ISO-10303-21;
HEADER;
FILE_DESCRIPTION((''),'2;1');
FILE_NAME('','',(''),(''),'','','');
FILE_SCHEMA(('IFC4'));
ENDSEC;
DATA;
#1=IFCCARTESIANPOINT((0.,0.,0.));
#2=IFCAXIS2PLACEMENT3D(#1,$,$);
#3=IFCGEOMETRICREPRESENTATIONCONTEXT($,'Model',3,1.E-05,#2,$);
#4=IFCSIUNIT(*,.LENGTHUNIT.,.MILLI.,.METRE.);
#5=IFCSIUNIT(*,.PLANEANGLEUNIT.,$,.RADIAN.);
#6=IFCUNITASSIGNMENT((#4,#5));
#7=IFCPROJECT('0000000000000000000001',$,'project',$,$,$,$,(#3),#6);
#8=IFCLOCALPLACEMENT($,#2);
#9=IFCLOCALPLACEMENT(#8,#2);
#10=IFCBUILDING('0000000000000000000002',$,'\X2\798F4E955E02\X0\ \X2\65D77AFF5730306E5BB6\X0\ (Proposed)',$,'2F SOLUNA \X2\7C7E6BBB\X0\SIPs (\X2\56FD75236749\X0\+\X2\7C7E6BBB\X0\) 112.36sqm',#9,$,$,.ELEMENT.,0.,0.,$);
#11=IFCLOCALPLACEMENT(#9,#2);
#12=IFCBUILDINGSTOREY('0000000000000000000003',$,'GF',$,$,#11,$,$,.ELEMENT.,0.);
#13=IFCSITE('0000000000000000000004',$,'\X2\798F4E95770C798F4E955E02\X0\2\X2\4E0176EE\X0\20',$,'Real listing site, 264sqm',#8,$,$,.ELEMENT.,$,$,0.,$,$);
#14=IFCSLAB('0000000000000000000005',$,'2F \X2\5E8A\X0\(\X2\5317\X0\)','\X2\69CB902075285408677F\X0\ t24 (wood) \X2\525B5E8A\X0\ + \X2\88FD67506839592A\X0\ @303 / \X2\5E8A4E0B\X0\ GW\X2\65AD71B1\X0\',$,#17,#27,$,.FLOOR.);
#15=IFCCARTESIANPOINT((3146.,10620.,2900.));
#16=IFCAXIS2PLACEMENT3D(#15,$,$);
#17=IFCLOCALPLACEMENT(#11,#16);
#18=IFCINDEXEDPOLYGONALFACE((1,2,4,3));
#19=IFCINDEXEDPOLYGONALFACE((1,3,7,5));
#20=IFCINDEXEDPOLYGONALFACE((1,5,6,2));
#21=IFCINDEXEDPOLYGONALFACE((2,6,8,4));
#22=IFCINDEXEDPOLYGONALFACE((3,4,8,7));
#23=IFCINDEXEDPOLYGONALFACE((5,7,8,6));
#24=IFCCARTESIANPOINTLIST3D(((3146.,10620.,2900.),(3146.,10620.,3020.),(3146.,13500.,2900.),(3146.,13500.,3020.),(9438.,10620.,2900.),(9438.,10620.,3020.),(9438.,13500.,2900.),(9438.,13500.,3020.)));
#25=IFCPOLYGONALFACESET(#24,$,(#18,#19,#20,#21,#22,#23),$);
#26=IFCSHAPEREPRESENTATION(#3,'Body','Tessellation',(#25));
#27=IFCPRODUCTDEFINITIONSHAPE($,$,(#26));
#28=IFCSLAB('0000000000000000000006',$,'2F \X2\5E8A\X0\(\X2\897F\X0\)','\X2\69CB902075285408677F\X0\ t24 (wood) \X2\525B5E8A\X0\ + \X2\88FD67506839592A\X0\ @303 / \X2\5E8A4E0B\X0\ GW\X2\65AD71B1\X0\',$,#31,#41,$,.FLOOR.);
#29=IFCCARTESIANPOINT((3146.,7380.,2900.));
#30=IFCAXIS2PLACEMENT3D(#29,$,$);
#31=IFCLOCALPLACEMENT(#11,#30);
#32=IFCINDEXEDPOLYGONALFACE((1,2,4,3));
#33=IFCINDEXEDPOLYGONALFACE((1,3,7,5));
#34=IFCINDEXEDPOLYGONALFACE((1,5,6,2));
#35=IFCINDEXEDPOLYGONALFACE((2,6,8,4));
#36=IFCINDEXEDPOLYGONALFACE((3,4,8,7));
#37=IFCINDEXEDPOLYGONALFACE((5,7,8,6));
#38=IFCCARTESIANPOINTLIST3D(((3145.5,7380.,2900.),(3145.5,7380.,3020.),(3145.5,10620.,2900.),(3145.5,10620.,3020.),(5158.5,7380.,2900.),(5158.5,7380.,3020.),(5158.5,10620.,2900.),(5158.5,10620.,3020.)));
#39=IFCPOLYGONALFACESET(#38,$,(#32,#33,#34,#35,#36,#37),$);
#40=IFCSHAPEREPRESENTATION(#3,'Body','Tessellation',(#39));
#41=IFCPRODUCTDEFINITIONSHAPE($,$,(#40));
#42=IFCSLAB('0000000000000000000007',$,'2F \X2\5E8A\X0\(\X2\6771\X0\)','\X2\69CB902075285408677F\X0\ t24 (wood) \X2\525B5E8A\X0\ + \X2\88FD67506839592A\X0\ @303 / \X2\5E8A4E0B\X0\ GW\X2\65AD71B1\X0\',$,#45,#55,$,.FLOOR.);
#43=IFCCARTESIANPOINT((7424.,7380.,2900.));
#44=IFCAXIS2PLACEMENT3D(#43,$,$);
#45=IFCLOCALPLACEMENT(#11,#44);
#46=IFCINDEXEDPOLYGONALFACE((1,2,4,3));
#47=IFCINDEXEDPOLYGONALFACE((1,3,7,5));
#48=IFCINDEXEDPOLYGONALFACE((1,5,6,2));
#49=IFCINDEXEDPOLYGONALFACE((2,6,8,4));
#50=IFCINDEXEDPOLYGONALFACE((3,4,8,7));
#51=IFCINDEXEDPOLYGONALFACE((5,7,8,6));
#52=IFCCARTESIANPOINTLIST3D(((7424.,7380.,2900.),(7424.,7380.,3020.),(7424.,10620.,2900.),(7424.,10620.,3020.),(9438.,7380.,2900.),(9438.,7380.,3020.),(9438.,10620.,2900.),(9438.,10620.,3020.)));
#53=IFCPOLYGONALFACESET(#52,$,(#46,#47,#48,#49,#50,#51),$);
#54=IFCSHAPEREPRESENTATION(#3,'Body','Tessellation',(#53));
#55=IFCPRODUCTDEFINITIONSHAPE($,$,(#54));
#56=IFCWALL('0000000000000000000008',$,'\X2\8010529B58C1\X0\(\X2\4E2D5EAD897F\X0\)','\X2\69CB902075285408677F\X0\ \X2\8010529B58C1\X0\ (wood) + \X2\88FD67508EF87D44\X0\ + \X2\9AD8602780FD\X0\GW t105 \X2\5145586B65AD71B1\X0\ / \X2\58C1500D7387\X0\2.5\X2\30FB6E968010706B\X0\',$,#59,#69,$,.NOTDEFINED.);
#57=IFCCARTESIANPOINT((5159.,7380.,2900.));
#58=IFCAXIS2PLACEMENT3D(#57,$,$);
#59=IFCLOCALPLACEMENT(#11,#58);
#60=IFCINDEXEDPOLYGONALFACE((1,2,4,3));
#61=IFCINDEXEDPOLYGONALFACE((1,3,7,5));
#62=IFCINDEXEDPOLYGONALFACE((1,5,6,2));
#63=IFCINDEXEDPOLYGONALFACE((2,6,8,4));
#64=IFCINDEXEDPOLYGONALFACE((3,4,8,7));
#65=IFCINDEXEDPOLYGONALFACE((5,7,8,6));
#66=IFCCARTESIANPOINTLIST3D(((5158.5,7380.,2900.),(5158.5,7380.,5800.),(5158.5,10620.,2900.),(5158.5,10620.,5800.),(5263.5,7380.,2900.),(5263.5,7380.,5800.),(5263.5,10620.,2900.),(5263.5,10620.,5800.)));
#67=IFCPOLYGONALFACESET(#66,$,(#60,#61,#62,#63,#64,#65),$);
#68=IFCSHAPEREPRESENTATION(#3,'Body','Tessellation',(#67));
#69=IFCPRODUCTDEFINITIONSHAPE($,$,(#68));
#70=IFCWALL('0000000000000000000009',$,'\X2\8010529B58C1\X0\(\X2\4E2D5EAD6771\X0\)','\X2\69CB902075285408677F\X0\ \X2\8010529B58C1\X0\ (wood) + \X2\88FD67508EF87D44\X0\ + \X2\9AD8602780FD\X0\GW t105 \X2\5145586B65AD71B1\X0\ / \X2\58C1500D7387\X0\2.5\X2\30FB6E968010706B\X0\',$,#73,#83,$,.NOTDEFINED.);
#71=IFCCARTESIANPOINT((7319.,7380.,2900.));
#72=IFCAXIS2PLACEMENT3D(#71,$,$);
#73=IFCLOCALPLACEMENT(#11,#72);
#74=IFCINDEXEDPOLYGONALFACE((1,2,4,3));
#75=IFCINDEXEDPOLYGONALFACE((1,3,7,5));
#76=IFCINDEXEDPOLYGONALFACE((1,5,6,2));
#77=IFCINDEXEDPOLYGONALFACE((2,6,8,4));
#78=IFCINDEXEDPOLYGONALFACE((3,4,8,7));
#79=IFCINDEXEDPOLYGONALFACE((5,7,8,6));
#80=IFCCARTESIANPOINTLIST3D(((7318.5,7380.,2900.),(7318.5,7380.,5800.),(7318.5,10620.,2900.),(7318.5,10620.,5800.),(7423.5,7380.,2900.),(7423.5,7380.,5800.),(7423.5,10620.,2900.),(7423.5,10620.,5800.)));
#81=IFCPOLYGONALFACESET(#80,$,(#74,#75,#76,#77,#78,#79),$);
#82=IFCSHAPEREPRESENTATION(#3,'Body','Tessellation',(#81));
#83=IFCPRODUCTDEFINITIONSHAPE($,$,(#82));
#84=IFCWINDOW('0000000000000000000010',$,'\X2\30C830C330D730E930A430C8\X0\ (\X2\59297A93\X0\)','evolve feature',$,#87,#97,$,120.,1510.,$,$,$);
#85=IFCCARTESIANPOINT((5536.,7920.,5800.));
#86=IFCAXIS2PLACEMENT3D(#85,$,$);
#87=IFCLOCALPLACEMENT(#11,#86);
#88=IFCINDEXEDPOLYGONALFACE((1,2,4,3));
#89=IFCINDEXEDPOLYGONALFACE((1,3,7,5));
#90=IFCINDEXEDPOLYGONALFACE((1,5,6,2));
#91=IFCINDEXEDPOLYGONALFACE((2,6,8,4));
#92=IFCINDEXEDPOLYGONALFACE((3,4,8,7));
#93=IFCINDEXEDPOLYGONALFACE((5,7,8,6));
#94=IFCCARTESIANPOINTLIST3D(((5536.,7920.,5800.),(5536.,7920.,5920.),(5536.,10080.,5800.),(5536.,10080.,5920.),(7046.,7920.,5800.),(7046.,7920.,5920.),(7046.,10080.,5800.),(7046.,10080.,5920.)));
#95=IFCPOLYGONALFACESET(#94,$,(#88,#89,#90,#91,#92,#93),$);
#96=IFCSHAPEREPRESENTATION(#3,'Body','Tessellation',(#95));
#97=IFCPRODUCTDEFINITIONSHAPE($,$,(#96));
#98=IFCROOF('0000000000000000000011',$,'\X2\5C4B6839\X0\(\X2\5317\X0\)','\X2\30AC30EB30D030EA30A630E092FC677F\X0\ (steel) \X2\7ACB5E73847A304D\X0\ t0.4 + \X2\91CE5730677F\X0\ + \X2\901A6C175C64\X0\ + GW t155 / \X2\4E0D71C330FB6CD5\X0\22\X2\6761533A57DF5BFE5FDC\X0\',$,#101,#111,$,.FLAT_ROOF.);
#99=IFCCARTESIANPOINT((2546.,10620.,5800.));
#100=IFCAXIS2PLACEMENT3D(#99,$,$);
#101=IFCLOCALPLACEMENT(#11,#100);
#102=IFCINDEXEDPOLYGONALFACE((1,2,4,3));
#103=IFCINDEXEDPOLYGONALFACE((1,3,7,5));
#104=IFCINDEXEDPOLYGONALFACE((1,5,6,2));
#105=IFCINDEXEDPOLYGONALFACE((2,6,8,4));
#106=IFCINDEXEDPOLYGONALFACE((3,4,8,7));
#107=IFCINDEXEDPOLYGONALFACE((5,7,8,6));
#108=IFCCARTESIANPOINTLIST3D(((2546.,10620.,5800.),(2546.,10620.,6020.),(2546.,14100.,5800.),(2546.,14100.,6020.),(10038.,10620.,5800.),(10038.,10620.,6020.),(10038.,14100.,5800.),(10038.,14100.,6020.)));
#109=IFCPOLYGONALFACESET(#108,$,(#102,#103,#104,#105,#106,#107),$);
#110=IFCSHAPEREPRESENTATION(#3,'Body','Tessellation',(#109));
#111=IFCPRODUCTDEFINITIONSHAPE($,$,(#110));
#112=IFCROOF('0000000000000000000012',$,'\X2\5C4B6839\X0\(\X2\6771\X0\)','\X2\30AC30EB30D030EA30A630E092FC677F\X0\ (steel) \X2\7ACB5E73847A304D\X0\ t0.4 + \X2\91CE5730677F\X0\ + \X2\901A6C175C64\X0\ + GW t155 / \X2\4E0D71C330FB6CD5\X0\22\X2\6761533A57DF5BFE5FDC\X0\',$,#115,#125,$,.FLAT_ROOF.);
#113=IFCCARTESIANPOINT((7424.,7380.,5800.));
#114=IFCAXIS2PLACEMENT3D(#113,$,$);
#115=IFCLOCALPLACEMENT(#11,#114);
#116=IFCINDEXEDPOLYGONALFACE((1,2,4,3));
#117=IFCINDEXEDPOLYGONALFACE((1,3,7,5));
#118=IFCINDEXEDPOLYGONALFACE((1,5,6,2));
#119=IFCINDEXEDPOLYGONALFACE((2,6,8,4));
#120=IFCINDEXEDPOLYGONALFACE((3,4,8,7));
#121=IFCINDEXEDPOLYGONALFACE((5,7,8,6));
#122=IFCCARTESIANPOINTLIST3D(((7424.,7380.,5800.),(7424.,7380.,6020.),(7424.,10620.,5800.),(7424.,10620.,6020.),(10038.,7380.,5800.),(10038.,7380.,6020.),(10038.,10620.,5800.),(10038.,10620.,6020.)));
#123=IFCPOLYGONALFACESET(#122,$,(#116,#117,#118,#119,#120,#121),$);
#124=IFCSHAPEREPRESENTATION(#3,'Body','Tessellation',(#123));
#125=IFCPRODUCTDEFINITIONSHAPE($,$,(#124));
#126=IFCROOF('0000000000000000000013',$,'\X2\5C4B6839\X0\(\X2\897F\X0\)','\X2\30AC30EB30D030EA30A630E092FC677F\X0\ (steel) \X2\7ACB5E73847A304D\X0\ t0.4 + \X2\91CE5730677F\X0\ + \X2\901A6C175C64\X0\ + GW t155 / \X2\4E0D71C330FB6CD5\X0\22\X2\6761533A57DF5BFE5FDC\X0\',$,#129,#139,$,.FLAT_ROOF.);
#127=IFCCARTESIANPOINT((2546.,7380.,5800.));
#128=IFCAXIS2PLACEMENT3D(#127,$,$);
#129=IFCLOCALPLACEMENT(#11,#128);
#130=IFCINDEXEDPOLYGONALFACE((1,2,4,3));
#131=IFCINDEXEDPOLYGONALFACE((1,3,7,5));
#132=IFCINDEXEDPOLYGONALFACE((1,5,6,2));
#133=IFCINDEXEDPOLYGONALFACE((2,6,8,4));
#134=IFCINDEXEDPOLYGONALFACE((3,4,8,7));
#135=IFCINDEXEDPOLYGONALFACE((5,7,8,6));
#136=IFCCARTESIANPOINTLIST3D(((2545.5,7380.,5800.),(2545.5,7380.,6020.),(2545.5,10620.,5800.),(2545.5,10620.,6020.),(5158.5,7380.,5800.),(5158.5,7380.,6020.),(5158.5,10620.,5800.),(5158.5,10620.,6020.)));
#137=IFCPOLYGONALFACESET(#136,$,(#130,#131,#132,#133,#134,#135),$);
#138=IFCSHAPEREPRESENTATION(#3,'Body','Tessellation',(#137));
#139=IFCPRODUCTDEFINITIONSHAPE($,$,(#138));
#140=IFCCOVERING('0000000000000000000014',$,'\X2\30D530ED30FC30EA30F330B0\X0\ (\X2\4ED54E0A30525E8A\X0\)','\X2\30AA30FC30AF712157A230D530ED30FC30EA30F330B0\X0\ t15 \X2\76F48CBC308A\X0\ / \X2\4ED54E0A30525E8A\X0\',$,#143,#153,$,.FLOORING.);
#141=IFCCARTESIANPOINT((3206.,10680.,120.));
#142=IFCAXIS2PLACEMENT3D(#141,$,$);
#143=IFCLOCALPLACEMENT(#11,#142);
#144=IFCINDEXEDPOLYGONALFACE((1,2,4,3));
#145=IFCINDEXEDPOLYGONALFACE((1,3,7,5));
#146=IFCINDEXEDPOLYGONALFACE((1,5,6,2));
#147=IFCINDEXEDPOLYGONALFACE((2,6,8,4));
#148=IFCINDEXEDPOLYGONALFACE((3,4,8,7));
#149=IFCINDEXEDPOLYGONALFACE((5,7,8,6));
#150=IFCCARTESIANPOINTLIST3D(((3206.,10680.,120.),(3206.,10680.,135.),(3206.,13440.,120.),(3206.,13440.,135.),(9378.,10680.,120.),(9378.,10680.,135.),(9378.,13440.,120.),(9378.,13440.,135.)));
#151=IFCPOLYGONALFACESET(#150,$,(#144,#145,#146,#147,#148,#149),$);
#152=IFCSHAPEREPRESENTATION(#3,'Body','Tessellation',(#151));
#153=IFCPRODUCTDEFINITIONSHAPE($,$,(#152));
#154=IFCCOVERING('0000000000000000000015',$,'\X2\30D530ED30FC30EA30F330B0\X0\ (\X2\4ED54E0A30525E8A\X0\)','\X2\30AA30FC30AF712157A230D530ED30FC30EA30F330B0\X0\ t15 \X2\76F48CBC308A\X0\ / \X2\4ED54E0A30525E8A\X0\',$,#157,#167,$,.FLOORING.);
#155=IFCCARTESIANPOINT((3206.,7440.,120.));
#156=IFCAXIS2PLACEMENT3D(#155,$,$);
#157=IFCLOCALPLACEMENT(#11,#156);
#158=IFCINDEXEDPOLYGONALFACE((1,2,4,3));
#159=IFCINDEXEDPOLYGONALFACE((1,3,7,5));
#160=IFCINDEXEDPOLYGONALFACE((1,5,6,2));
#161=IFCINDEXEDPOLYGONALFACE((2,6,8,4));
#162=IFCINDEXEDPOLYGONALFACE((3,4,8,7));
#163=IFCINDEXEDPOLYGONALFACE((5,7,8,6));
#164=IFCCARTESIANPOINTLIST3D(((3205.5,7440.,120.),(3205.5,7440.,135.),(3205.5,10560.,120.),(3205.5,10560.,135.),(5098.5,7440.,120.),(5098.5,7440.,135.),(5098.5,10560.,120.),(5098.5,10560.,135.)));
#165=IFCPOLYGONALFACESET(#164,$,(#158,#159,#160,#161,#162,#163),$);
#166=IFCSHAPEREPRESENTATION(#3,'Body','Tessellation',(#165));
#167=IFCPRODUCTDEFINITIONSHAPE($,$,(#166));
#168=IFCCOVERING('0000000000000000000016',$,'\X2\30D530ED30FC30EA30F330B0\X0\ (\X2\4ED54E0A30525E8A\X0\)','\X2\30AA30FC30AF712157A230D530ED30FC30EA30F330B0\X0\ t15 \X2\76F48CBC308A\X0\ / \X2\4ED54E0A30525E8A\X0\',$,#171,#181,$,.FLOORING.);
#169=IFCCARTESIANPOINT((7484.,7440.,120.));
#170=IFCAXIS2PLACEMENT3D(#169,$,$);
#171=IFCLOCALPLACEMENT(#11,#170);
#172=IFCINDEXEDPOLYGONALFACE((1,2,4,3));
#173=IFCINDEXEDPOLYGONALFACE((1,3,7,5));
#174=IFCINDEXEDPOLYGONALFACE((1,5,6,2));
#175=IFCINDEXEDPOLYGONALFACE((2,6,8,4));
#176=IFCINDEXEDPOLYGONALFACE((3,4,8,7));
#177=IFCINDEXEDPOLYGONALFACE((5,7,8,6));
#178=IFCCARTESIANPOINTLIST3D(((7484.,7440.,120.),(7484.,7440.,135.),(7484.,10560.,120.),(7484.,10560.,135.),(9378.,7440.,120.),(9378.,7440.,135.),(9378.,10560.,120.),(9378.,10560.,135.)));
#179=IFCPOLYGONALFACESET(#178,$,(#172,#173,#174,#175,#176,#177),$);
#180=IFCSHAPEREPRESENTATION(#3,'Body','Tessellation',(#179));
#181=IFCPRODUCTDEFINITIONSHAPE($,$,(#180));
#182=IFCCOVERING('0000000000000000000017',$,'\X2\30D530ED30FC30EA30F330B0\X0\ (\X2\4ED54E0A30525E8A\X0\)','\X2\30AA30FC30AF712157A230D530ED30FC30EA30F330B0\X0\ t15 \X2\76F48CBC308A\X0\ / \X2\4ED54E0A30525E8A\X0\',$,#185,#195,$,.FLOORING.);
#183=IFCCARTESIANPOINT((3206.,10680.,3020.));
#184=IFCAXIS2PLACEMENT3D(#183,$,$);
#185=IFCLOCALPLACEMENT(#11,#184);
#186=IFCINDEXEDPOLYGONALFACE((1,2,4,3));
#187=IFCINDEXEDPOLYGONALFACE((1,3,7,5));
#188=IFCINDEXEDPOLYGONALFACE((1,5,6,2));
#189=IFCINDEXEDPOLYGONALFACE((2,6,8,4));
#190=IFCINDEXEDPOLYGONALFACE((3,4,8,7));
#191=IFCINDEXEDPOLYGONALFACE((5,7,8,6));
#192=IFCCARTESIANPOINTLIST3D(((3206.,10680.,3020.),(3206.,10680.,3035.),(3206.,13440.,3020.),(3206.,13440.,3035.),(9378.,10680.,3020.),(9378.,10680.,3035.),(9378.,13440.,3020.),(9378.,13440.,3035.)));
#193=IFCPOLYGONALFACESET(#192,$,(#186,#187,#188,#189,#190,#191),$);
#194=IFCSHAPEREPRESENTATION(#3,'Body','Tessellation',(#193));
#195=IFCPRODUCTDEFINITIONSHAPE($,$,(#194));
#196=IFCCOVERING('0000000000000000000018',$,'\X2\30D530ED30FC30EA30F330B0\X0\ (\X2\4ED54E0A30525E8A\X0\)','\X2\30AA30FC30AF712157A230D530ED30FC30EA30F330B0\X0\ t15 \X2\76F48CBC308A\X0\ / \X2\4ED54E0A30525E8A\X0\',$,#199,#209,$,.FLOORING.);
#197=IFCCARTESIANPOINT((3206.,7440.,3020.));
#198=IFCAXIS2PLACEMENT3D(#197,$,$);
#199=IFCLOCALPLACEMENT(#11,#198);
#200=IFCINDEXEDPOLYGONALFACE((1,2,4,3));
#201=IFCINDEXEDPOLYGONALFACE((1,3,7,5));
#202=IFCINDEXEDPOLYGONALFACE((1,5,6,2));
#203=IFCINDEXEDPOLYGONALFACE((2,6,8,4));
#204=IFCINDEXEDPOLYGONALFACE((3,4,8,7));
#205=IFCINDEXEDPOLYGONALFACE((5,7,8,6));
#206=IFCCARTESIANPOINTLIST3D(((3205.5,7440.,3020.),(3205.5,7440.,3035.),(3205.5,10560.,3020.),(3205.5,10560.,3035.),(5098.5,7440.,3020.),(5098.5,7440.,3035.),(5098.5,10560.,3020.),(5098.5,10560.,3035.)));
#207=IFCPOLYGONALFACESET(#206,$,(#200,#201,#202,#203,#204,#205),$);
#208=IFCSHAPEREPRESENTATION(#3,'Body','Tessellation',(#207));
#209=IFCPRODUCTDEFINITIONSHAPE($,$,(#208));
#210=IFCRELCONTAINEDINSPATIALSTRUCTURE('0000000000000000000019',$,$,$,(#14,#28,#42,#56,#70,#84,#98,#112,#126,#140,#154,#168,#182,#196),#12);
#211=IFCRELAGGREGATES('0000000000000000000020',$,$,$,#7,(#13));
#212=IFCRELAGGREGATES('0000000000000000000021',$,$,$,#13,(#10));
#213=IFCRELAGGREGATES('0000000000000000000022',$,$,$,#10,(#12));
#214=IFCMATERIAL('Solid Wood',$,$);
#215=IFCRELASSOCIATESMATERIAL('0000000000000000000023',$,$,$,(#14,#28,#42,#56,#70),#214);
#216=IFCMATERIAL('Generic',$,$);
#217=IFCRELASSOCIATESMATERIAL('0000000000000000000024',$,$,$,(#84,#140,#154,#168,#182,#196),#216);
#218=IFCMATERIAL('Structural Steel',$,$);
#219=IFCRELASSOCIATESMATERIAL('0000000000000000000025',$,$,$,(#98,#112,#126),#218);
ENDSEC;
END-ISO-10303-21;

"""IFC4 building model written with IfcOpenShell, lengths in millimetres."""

from ifc_helpers import new_model, si_unit, frame, frame_2d, origin, place, context, project, spatial, rectangle, extrude, material, element, save


model = new_model("IFC4")

# Units and contexts
model_context = context("Model", 3, precision=1e-05, world=origin())
ifc_project = project(units=[si_unit("LENGTHUNIT", "METRE", prefix="MILLI"), si_unit("PLANEANGLEUNIT", "RADIAN")], contexts=[model_context])

# Site, building, storey
site_placement = place(None, origin())
site = spatial("IfcSite", under=ifc_project, at=site_placement, Name="福井県福井市2丁目20", ObjectType="Real listing site, 264sqm", CompositionType="ELEMENT", RefElevation=0.0)
building_placement = place(site_placement, origin())
building = spatial("IfcBuilding", under=site, at=building_placement, Name="福井市 旗竿地の家 (Proposed)", ObjectType="2F SOLUNA 籾殻SIPs (国産杉+籾殻) 112.36sqm", CompositionType="ELEMENT", ElevationOfRefHeight=0.0, ElevationOfTerrain=0.0)
storey_placement = place(building_placement, origin())
storey = spatial("IfcBuildingStorey", under=building, at=storey_placement, Name="GF", CompositionType="ELEMENT", Elevation=0.0)

# Slabs
ifc_material_1 = material(Name="Solid Wood")
slab_1_placement = place(storey_placement, frame((3146.0, 10620.0, 2900.0)))
element("IfcSlab", 1, at=slab_1_placement, inside=storey, material=ifc_material_1, Name="2F 床(北)", Description="構造用合板 t24 (wood) 剛床 + 製材根太 @303 / 床下 GW断熱", PredefinedType="FLOOR", context=model_context, shape_type="SweptSolid", body=[
    extrude(rectangle(XDim=6292.0, YDim=2880.0, at=frame_2d((3146.0, 1440.0))), frame((3146.0, 10620.0, 2900.0)), (0.0, 0.0, 1.0), 120.0),
])
slab_2_placement = place(storey_placement, frame((3146.0, 7380.0, 2900.0)))
element("IfcSlab", 2, at=slab_2_placement, inside=storey, material=ifc_material_1, Name="2F 床(西)", Description="構造用合板 t24 (wood) 剛床 + 製材根太 @303 / 床下 GW断熱", PredefinedType="FLOOR", context=model_context, shape_type="SweptSolid", body=[
    extrude(rectangle(XDim=2013.0, YDim=3240.0, at=frame_2d((1006.0, 1620.0))), frame((3146.0, 7380.0, 2900.0)), (0.0, 0.0, 1.0), 120.0),
])
slab_3_placement = place(storey_placement, frame((7424.0, 7380.0, 2900.0)))
element("IfcSlab", 3, at=slab_3_placement, inside=storey, material=ifc_material_1, Name="2F 床(東)", Description="構造用合板 t24 (wood) 剛床 + 製材根太 @303 / 床下 GW断熱", PredefinedType="FLOOR", context=model_context, shape_type="SweptSolid", body=[
    extrude(rectangle(XDim=2014.0, YDim=3240.0, at=frame_2d((1007.0, 1620.0))), frame((7424.0, 7380.0, 2900.0)), (0.0, 0.0, 1.0), 120.0),
])

# Walls
wall_1_placement = place(storey_placement, frame((5159.0, 7380.0, 2900.0)))
element("IfcWall", 4, at=wall_1_placement, inside=storey, material=ifc_material_1, Name="耐力壁(中庭西)", Description="構造用合板 耐力壁 (wood) + 製材軸組 + 高性能GW t105 充填断熱 / 壁倍率2.5・準耐火", PredefinedType="NOTDEFINED", context=model_context, shape_type="SweptSolid", body=[
    extrude(rectangle(XDim=105.0, YDim=3240.0, at=frame_2d((52.0, 1620.0))), frame((5159.0, 7380.0, 2900.0)), (0.0, 0.0, 1.0), 2900.0),
])
wall_2_placement = place(storey_placement, frame((7319.0, 7380.0, 2900.0)))
element("IfcWall", 5, at=wall_2_placement, inside=storey, material=ifc_material_1, Name="耐力壁(中庭東)", Description="構造用合板 耐力壁 (wood) + 製材軸組 + 高性能GW t105 充填断熱 / 壁倍率2.5・準耐火", PredefinedType="NOTDEFINED", context=model_context, shape_type="SweptSolid", body=[
    extrude(rectangle(XDim=105.0, YDim=3240.0, at=frame_2d((52.0, 1620.0))), frame((7319.0, 7380.0, 2900.0)), (0.0, 0.0, 1.0), 2900.0),
])

# Window
ifc_material_2 = material(Name="Generic")
window_1_placement = place(storey_placement, frame((5536.0, 7920.0, 5800.0)))
element("IfcWindow", 6, at=window_1_placement, inside=storey, material=ifc_material_2, Name="トップライト (天窓)", Description="evolve feature", OverallHeight=120.0, OverallWidth=1510.0, context=model_context, shape_type="SweptSolid", body=[
    extrude(rectangle(XDim=1510.0, YDim=2160.0, at=frame_2d((755.0, 1080.0))), frame((5536.0, 7920.0, 5800.0)), (0.0, 0.0, 1.0), 120.0),
])

# Roofs
ifc_material_3 = material(Name="Structural Steel")
roof_1_placement = place(storey_placement, frame((2546.0, 10620.0, 5800.0)))
element("IfcRoof", 7, at=roof_1_placement, inside=storey, material=ifc_material_3, Name="屋根(北)", Description="ガルバリウム鋼板 (steel) 立平葺き t0.4 + 野地板 + 通気層 + GW t155 / 不燃・法22条区域対応", PredefinedType="FLAT_ROOF", context=model_context, shape_type="SweptSolid", body=[
    extrude(rectangle(XDim=7492.0, YDim=3480.0, at=frame_2d((3746.0, 1740.0))), frame((2546.0, 10620.0, 5800.0)), (0.0, 0.0, 1.0), 220.0),
])
roof_2_placement = place(storey_placement, frame((7424.0, 7380.0, 5800.0)))
element("IfcRoof", 8, at=roof_2_placement, inside=storey, material=ifc_material_3, Name="屋根(東)", Description="ガルバリウム鋼板 (steel) 立平葺き t0.4 + 野地板 + 通気層 + GW t155 / 不燃・法22条区域対応", PredefinedType="FLAT_ROOF", context=model_context, shape_type="SweptSolid", body=[
    extrude(rectangle(XDim=2614.0, YDim=3240.0, at=frame_2d((1307.0, 1620.0))), frame((7424.0, 7380.0, 5800.0)), (0.0, 0.0, 1.0), 220.0),
])
roof_3_placement = place(storey_placement, frame((2546.0, 7380.0, 5800.0)))
element("IfcRoof", 9, at=roof_3_placement, inside=storey, material=ifc_material_3, Name="屋根(西)", Description="ガルバリウム鋼板 (steel) 立平葺き t0.4 + 野地板 + 通気層 + GW t155 / 不燃・法22条区域対応", PredefinedType="FLAT_ROOF", context=model_context, shape_type="SweptSolid", body=[
    extrude(rectangle(XDim=2613.0, YDim=3240.0, at=frame_2d((1306.0, 1620.0))), frame((2546.0, 7380.0, 5800.0)), (0.0, 0.0, 1.0), 220.0),
])

# Coverings
covering_1_placement = place(storey_placement, frame((3206.0, 10680.0, 120.0)))
element("IfcCovering", 10, at=covering_1_placement, inside=storey, material=ifc_material_2, Name="フローリング (仕上げ床)", Description="オーク無垢フローリング t15 直貼り / 仕上げ床", PredefinedType="FLOORING", context=model_context, shape_type="SweptSolid", body=[
    extrude(rectangle(XDim=6172.0, YDim=2760.0, at=frame_2d((3086.0, 1380.0))), frame((3206.0, 10680.0, 120.0)), (0.0, 0.0, 1.0), 15.0),
])
covering_2_placement = place(storey_placement, frame((3206.0, 7440.0, 120.0)))
element("IfcCovering", 11, at=covering_2_placement, inside=storey, material=ifc_material_2, Name="フローリング (仕上げ床)", Description="オーク無垢フローリング t15 直貼り / 仕上げ床", PredefinedType="FLOORING", context=model_context, shape_type="SweptSolid", body=[
    extrude(rectangle(XDim=1893.0, YDim=3120.0, at=frame_2d((946.0, 1560.0))), frame((3206.0, 7440.0, 120.0)), (0.0, 0.0, 1.0), 15.0),
])
covering_3_placement = place(storey_placement, frame((7484.0, 7440.0, 120.0)))
element("IfcCovering", 12, at=covering_3_placement, inside=storey, material=ifc_material_2, Name="フローリング (仕上げ床)", Description="オーク無垢フローリング t15 直貼り / 仕上げ床", PredefinedType="FLOORING", context=model_context, shape_type="SweptSolid", body=[
    extrude(rectangle(XDim=1894.0, YDim=3120.0, at=frame_2d((947.0, 1560.0))), frame((7484.0, 7440.0, 120.0)), (0.0, 0.0, 1.0), 15.0),
])
covering_4_placement = place(storey_placement, frame((3206.0, 10680.0, 3020.0)))
element("IfcCovering", 13, at=covering_4_placement, inside=storey, material=ifc_material_2, Name="フローリング (仕上げ床)", Description="オーク無垢フローリング t15 直貼り / 仕上げ床", PredefinedType="FLOORING", context=model_context, shape_type="SweptSolid", body=[
    extrude(rectangle(XDim=6172.0, YDim=2760.0, at=frame_2d((3086.0, 1380.0))), frame((3206.0, 10680.0, 3020.0)), (0.0, 0.0, 1.0), 15.0),
])
covering_5_placement = place(storey_placement, frame((3206.0, 7440.0, 3020.0)))
element("IfcCovering", 14, at=covering_5_placement, inside=storey, material=ifc_material_2, Name="フローリング (仕上げ床)", Description="オーク無垢フローリング t15 直貼り / 仕上げ床", PredefinedType="FLOORING", context=model_context, shape_type="SweptSolid", body=[
    extrude(rectangle(XDim=1893.0, YDim=3120.0, at=frame_2d((946.0, 1560.0))), frame((3206.0, 7440.0, 3020.0)), (0.0, 0.0, 1.0), 15.0),
])

save(model, "model.ifc")
